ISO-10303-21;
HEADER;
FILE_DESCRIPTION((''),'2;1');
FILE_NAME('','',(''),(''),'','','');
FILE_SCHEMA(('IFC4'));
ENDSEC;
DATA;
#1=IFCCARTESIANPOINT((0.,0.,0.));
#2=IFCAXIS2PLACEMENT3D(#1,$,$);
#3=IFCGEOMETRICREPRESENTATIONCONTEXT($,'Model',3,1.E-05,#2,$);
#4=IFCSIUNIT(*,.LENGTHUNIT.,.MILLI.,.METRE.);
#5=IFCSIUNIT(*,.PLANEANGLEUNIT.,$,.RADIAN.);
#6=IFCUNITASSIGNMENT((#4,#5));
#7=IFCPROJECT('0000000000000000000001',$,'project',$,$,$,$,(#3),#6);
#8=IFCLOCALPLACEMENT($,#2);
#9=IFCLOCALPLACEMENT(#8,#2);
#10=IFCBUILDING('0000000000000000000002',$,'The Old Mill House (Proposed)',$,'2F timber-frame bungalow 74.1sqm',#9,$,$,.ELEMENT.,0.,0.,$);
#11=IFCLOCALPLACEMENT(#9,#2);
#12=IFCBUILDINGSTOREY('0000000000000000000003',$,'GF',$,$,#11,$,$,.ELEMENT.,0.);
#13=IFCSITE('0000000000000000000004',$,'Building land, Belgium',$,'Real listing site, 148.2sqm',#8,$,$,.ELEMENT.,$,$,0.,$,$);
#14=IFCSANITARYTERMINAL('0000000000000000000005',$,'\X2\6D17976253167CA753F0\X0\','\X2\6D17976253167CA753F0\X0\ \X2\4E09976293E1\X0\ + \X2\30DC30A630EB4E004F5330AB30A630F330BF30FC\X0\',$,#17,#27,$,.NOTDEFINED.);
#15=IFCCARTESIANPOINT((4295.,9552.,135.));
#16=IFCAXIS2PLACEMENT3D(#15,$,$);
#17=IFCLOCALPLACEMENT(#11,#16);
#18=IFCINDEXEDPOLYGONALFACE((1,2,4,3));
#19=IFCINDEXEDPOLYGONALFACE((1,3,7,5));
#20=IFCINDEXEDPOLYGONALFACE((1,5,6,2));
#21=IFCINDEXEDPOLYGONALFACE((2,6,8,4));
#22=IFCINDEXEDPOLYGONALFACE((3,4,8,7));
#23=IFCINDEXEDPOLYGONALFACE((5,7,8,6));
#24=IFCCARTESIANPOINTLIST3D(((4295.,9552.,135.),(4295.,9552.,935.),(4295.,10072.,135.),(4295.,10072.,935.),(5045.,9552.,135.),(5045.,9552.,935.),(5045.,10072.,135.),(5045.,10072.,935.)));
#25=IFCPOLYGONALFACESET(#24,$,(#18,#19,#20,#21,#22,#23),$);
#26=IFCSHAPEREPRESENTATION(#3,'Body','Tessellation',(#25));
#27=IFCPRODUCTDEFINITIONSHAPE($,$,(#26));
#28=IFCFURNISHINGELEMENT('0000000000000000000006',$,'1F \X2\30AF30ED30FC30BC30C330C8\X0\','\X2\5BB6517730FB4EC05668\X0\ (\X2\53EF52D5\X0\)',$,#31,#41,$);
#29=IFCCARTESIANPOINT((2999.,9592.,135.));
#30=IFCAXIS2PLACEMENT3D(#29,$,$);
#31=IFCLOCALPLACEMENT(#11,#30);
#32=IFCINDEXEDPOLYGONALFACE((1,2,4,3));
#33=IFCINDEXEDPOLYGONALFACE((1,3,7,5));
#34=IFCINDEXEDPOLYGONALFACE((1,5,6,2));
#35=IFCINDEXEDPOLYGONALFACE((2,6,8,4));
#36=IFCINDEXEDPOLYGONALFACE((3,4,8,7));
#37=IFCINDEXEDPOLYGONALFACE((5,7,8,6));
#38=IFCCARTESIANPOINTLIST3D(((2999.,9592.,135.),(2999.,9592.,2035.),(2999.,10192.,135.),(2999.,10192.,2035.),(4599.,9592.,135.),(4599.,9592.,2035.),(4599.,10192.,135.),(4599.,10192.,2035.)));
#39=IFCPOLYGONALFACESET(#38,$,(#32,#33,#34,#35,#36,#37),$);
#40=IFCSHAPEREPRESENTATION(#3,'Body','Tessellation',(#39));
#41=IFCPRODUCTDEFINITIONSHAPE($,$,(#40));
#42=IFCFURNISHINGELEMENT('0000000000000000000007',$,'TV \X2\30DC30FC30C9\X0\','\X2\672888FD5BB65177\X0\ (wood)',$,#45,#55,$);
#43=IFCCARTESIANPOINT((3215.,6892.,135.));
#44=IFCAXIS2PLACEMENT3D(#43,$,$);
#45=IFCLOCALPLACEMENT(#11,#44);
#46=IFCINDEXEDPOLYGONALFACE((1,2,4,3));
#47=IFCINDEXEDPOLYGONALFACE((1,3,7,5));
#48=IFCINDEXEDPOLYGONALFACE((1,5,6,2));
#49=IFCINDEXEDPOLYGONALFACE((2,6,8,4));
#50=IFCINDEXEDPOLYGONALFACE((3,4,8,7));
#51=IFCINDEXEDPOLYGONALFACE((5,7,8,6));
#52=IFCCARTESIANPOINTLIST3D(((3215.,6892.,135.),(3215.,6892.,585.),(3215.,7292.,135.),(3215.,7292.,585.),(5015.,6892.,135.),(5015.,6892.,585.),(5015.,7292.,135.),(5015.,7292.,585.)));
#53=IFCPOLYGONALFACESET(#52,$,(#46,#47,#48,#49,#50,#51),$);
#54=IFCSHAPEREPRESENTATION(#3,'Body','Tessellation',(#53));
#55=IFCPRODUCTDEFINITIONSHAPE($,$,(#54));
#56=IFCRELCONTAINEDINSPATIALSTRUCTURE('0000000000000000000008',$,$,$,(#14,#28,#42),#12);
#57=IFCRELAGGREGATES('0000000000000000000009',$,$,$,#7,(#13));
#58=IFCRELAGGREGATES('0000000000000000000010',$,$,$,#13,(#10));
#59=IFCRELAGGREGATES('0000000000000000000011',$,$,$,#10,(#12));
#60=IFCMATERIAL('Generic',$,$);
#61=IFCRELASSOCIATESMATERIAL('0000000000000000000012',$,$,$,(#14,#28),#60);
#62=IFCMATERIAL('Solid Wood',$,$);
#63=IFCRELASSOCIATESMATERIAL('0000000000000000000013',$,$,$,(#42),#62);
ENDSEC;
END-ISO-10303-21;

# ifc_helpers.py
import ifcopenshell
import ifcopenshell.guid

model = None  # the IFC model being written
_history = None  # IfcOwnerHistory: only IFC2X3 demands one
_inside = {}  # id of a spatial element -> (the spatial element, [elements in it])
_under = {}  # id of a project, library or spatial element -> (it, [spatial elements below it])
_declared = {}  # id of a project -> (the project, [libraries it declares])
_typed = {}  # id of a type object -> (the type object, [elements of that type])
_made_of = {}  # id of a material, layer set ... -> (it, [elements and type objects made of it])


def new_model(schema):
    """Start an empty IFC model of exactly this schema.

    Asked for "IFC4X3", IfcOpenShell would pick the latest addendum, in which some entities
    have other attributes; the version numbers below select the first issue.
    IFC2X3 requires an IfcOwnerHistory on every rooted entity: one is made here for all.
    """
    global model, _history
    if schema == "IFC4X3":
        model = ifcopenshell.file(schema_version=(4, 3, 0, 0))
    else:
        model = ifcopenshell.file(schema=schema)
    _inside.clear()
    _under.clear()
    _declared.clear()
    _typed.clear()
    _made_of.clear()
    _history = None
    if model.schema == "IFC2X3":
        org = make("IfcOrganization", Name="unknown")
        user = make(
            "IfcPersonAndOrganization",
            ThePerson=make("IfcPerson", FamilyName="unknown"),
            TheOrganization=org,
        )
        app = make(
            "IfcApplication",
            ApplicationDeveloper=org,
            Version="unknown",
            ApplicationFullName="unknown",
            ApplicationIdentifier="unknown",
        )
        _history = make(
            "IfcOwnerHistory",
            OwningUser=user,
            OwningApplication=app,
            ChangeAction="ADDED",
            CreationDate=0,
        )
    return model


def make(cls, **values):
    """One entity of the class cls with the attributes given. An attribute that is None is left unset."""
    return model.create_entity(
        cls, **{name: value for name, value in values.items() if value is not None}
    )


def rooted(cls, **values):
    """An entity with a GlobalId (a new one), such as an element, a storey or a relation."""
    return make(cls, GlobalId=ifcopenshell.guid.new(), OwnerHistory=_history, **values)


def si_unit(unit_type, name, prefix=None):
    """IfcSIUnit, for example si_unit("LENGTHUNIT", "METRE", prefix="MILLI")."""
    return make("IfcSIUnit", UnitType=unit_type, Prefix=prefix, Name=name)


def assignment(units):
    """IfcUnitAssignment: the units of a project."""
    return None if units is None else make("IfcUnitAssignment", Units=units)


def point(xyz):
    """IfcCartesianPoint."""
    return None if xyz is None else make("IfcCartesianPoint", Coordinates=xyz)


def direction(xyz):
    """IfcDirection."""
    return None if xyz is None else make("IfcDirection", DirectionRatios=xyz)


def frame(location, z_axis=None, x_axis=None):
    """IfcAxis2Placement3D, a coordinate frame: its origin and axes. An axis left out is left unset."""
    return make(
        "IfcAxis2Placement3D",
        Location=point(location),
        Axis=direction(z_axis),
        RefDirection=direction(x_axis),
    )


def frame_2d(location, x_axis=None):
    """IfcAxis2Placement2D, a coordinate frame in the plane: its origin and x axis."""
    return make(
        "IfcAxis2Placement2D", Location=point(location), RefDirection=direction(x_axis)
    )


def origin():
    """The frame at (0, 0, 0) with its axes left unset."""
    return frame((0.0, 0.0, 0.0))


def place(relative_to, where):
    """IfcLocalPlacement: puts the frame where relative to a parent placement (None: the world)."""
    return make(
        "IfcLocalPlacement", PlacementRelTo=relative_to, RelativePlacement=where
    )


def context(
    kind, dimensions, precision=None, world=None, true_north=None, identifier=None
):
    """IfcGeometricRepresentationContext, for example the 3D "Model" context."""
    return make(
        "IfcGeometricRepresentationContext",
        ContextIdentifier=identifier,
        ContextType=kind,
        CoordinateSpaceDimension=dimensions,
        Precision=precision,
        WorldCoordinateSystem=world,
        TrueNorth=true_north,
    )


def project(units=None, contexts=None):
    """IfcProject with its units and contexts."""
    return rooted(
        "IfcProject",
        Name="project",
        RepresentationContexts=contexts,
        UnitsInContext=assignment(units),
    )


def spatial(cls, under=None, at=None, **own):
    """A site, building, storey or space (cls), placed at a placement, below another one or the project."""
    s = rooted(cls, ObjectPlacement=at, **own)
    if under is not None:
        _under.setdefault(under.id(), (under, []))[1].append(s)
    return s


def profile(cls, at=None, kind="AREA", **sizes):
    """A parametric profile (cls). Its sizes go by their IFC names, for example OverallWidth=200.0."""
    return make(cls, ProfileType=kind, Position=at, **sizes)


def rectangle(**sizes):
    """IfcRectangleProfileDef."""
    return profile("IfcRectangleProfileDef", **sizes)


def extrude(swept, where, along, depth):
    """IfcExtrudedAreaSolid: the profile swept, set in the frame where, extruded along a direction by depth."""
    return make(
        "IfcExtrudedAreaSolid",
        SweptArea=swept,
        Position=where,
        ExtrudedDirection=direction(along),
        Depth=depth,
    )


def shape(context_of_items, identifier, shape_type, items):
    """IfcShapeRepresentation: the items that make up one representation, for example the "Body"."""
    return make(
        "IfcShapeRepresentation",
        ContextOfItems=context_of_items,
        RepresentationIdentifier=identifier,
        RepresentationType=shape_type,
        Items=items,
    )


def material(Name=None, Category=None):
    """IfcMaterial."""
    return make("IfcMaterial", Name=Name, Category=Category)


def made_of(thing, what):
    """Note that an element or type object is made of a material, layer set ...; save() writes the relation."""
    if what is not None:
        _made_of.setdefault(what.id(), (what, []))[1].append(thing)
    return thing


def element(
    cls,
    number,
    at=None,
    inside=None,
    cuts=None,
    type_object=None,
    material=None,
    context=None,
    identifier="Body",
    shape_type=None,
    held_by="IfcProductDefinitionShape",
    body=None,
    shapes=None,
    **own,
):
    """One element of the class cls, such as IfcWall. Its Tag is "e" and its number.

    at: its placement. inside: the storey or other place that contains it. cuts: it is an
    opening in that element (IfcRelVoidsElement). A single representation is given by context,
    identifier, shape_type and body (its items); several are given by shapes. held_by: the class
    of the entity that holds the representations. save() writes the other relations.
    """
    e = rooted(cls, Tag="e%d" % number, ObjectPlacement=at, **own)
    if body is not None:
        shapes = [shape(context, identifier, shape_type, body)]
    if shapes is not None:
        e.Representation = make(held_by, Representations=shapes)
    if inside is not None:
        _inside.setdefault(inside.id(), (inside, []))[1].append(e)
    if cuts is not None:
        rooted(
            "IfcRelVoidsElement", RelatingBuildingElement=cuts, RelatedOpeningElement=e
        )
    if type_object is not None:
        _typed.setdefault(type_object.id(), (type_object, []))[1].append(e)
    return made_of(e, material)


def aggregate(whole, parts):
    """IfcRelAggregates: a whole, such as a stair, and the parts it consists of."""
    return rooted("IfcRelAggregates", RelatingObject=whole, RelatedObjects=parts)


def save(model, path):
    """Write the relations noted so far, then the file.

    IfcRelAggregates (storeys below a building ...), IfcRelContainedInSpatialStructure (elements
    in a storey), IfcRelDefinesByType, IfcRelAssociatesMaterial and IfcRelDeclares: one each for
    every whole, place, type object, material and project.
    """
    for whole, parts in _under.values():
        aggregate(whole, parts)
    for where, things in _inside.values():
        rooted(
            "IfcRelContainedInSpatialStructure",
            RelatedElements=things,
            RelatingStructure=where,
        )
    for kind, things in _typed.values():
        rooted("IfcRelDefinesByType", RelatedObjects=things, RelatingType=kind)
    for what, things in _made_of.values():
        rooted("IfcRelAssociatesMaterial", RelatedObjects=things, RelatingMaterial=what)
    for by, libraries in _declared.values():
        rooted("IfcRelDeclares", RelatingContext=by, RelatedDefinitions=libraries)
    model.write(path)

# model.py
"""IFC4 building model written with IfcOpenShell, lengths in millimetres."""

from ifc_helpers import new_model, si_unit, frame, frame_2d, origin, place, context, project, spatial, rectangle, extrude, material, element, save


model = new_model("IFC4")

# Units and contexts
model_context = context("Model", 3, precision=1e-05, world=origin())
ifc_project = project(units=[si_unit("LENGTHUNIT", "METRE", prefix="MILLI"), si_unit("PLANEANGLEUNIT", "RADIAN")], contexts=[model_context])

# Site, building, storey
site_placement = place(None, origin())
site = spatial("IfcSite", under=ifc_project, at=site_placement, Name="Building land, Belgium", ObjectType="Real listing site, 148.2sqm", CompositionType="ELEMENT", RefElevation=0.0)
building_placement = place(site_placement, origin())
building = spatial("IfcBuilding", under=site, at=building_placement, Name="The Old Mill House (Proposed)", ObjectType="2F timber-frame bungalow 74.1sqm", CompositionType="ELEMENT", ElevationOfRefHeight=0.0, ElevationOfTerrain=0.0)
storey_placement = place(building_placement, origin())
storey = spatial("IfcBuildingStorey", under=building, at=storey_placement, Name="GF", CompositionType="ELEMENT", Elevation=0.0)

# Shared definitions
ifc_material_1 = material(Name="Solid Wood")

# Shared definitions
ifc_material_2 = material(Name="Generic")

# Sanitary terminal
sanitary_terminal_1_placement = place(storey_placement, frame((4295.0, 9552.0, 135.0)))
element("IfcSanitaryTerminal", 1, at=sanitary_terminal_1_placement, inside=storey, material=ifc_material_2, Name="洗面化粧台", Description="洗面化粧台 三面鏡 + ボウル一体カウンター", PredefinedType="NOTDEFINED", context=model_context, shape_type="SweptSolid", body=[
    extrude(rectangle(XDim=750.0, YDim=520.0, at=frame_2d((375.0, 260.0))), frame((4295.0, 9552.0, 135.0)), (0.0, 0.0, 1.0), 800.0),
])

# Furnishing elements
furnishing_1_placement = place(storey_placement, frame((2999.0, 9592.0, 135.0)))
element("IfcFurnishingElement", 2, at=furnishing_1_placement, inside=storey, material=ifc_material_2, Name="1F クローゼット", Description="家具・什器 (可動)", context=model_context, shape_type="SweptSolid", body=[
    extrude(rectangle(XDim=1600.0, YDim=600.0, at=frame_2d((800.0, 300.0))), frame((2999.0, 9592.0, 135.0)), (0.0, 0.0, 1.0), 1900.0),
])
furnishing_2_placement = place(storey_placement, frame((3215.0, 6892.0, 135.0)))
element("IfcFurnishingElement", 3, at=furnishing_2_placement, inside=storey, material=ifc_material_1, Name="TV ボード", Description="木製家具 (wood)", context=model_context, shape_type="SweptSolid", body=[
    extrude(rectangle(XDim=1800.0, YDim=400.0, at=frame_2d((900.0, 200.0))), frame((3215.0, 6892.0, 135.0)), (0.0, 0.0, 1.0), 450.0),
])

save(model, "model.ifc")
